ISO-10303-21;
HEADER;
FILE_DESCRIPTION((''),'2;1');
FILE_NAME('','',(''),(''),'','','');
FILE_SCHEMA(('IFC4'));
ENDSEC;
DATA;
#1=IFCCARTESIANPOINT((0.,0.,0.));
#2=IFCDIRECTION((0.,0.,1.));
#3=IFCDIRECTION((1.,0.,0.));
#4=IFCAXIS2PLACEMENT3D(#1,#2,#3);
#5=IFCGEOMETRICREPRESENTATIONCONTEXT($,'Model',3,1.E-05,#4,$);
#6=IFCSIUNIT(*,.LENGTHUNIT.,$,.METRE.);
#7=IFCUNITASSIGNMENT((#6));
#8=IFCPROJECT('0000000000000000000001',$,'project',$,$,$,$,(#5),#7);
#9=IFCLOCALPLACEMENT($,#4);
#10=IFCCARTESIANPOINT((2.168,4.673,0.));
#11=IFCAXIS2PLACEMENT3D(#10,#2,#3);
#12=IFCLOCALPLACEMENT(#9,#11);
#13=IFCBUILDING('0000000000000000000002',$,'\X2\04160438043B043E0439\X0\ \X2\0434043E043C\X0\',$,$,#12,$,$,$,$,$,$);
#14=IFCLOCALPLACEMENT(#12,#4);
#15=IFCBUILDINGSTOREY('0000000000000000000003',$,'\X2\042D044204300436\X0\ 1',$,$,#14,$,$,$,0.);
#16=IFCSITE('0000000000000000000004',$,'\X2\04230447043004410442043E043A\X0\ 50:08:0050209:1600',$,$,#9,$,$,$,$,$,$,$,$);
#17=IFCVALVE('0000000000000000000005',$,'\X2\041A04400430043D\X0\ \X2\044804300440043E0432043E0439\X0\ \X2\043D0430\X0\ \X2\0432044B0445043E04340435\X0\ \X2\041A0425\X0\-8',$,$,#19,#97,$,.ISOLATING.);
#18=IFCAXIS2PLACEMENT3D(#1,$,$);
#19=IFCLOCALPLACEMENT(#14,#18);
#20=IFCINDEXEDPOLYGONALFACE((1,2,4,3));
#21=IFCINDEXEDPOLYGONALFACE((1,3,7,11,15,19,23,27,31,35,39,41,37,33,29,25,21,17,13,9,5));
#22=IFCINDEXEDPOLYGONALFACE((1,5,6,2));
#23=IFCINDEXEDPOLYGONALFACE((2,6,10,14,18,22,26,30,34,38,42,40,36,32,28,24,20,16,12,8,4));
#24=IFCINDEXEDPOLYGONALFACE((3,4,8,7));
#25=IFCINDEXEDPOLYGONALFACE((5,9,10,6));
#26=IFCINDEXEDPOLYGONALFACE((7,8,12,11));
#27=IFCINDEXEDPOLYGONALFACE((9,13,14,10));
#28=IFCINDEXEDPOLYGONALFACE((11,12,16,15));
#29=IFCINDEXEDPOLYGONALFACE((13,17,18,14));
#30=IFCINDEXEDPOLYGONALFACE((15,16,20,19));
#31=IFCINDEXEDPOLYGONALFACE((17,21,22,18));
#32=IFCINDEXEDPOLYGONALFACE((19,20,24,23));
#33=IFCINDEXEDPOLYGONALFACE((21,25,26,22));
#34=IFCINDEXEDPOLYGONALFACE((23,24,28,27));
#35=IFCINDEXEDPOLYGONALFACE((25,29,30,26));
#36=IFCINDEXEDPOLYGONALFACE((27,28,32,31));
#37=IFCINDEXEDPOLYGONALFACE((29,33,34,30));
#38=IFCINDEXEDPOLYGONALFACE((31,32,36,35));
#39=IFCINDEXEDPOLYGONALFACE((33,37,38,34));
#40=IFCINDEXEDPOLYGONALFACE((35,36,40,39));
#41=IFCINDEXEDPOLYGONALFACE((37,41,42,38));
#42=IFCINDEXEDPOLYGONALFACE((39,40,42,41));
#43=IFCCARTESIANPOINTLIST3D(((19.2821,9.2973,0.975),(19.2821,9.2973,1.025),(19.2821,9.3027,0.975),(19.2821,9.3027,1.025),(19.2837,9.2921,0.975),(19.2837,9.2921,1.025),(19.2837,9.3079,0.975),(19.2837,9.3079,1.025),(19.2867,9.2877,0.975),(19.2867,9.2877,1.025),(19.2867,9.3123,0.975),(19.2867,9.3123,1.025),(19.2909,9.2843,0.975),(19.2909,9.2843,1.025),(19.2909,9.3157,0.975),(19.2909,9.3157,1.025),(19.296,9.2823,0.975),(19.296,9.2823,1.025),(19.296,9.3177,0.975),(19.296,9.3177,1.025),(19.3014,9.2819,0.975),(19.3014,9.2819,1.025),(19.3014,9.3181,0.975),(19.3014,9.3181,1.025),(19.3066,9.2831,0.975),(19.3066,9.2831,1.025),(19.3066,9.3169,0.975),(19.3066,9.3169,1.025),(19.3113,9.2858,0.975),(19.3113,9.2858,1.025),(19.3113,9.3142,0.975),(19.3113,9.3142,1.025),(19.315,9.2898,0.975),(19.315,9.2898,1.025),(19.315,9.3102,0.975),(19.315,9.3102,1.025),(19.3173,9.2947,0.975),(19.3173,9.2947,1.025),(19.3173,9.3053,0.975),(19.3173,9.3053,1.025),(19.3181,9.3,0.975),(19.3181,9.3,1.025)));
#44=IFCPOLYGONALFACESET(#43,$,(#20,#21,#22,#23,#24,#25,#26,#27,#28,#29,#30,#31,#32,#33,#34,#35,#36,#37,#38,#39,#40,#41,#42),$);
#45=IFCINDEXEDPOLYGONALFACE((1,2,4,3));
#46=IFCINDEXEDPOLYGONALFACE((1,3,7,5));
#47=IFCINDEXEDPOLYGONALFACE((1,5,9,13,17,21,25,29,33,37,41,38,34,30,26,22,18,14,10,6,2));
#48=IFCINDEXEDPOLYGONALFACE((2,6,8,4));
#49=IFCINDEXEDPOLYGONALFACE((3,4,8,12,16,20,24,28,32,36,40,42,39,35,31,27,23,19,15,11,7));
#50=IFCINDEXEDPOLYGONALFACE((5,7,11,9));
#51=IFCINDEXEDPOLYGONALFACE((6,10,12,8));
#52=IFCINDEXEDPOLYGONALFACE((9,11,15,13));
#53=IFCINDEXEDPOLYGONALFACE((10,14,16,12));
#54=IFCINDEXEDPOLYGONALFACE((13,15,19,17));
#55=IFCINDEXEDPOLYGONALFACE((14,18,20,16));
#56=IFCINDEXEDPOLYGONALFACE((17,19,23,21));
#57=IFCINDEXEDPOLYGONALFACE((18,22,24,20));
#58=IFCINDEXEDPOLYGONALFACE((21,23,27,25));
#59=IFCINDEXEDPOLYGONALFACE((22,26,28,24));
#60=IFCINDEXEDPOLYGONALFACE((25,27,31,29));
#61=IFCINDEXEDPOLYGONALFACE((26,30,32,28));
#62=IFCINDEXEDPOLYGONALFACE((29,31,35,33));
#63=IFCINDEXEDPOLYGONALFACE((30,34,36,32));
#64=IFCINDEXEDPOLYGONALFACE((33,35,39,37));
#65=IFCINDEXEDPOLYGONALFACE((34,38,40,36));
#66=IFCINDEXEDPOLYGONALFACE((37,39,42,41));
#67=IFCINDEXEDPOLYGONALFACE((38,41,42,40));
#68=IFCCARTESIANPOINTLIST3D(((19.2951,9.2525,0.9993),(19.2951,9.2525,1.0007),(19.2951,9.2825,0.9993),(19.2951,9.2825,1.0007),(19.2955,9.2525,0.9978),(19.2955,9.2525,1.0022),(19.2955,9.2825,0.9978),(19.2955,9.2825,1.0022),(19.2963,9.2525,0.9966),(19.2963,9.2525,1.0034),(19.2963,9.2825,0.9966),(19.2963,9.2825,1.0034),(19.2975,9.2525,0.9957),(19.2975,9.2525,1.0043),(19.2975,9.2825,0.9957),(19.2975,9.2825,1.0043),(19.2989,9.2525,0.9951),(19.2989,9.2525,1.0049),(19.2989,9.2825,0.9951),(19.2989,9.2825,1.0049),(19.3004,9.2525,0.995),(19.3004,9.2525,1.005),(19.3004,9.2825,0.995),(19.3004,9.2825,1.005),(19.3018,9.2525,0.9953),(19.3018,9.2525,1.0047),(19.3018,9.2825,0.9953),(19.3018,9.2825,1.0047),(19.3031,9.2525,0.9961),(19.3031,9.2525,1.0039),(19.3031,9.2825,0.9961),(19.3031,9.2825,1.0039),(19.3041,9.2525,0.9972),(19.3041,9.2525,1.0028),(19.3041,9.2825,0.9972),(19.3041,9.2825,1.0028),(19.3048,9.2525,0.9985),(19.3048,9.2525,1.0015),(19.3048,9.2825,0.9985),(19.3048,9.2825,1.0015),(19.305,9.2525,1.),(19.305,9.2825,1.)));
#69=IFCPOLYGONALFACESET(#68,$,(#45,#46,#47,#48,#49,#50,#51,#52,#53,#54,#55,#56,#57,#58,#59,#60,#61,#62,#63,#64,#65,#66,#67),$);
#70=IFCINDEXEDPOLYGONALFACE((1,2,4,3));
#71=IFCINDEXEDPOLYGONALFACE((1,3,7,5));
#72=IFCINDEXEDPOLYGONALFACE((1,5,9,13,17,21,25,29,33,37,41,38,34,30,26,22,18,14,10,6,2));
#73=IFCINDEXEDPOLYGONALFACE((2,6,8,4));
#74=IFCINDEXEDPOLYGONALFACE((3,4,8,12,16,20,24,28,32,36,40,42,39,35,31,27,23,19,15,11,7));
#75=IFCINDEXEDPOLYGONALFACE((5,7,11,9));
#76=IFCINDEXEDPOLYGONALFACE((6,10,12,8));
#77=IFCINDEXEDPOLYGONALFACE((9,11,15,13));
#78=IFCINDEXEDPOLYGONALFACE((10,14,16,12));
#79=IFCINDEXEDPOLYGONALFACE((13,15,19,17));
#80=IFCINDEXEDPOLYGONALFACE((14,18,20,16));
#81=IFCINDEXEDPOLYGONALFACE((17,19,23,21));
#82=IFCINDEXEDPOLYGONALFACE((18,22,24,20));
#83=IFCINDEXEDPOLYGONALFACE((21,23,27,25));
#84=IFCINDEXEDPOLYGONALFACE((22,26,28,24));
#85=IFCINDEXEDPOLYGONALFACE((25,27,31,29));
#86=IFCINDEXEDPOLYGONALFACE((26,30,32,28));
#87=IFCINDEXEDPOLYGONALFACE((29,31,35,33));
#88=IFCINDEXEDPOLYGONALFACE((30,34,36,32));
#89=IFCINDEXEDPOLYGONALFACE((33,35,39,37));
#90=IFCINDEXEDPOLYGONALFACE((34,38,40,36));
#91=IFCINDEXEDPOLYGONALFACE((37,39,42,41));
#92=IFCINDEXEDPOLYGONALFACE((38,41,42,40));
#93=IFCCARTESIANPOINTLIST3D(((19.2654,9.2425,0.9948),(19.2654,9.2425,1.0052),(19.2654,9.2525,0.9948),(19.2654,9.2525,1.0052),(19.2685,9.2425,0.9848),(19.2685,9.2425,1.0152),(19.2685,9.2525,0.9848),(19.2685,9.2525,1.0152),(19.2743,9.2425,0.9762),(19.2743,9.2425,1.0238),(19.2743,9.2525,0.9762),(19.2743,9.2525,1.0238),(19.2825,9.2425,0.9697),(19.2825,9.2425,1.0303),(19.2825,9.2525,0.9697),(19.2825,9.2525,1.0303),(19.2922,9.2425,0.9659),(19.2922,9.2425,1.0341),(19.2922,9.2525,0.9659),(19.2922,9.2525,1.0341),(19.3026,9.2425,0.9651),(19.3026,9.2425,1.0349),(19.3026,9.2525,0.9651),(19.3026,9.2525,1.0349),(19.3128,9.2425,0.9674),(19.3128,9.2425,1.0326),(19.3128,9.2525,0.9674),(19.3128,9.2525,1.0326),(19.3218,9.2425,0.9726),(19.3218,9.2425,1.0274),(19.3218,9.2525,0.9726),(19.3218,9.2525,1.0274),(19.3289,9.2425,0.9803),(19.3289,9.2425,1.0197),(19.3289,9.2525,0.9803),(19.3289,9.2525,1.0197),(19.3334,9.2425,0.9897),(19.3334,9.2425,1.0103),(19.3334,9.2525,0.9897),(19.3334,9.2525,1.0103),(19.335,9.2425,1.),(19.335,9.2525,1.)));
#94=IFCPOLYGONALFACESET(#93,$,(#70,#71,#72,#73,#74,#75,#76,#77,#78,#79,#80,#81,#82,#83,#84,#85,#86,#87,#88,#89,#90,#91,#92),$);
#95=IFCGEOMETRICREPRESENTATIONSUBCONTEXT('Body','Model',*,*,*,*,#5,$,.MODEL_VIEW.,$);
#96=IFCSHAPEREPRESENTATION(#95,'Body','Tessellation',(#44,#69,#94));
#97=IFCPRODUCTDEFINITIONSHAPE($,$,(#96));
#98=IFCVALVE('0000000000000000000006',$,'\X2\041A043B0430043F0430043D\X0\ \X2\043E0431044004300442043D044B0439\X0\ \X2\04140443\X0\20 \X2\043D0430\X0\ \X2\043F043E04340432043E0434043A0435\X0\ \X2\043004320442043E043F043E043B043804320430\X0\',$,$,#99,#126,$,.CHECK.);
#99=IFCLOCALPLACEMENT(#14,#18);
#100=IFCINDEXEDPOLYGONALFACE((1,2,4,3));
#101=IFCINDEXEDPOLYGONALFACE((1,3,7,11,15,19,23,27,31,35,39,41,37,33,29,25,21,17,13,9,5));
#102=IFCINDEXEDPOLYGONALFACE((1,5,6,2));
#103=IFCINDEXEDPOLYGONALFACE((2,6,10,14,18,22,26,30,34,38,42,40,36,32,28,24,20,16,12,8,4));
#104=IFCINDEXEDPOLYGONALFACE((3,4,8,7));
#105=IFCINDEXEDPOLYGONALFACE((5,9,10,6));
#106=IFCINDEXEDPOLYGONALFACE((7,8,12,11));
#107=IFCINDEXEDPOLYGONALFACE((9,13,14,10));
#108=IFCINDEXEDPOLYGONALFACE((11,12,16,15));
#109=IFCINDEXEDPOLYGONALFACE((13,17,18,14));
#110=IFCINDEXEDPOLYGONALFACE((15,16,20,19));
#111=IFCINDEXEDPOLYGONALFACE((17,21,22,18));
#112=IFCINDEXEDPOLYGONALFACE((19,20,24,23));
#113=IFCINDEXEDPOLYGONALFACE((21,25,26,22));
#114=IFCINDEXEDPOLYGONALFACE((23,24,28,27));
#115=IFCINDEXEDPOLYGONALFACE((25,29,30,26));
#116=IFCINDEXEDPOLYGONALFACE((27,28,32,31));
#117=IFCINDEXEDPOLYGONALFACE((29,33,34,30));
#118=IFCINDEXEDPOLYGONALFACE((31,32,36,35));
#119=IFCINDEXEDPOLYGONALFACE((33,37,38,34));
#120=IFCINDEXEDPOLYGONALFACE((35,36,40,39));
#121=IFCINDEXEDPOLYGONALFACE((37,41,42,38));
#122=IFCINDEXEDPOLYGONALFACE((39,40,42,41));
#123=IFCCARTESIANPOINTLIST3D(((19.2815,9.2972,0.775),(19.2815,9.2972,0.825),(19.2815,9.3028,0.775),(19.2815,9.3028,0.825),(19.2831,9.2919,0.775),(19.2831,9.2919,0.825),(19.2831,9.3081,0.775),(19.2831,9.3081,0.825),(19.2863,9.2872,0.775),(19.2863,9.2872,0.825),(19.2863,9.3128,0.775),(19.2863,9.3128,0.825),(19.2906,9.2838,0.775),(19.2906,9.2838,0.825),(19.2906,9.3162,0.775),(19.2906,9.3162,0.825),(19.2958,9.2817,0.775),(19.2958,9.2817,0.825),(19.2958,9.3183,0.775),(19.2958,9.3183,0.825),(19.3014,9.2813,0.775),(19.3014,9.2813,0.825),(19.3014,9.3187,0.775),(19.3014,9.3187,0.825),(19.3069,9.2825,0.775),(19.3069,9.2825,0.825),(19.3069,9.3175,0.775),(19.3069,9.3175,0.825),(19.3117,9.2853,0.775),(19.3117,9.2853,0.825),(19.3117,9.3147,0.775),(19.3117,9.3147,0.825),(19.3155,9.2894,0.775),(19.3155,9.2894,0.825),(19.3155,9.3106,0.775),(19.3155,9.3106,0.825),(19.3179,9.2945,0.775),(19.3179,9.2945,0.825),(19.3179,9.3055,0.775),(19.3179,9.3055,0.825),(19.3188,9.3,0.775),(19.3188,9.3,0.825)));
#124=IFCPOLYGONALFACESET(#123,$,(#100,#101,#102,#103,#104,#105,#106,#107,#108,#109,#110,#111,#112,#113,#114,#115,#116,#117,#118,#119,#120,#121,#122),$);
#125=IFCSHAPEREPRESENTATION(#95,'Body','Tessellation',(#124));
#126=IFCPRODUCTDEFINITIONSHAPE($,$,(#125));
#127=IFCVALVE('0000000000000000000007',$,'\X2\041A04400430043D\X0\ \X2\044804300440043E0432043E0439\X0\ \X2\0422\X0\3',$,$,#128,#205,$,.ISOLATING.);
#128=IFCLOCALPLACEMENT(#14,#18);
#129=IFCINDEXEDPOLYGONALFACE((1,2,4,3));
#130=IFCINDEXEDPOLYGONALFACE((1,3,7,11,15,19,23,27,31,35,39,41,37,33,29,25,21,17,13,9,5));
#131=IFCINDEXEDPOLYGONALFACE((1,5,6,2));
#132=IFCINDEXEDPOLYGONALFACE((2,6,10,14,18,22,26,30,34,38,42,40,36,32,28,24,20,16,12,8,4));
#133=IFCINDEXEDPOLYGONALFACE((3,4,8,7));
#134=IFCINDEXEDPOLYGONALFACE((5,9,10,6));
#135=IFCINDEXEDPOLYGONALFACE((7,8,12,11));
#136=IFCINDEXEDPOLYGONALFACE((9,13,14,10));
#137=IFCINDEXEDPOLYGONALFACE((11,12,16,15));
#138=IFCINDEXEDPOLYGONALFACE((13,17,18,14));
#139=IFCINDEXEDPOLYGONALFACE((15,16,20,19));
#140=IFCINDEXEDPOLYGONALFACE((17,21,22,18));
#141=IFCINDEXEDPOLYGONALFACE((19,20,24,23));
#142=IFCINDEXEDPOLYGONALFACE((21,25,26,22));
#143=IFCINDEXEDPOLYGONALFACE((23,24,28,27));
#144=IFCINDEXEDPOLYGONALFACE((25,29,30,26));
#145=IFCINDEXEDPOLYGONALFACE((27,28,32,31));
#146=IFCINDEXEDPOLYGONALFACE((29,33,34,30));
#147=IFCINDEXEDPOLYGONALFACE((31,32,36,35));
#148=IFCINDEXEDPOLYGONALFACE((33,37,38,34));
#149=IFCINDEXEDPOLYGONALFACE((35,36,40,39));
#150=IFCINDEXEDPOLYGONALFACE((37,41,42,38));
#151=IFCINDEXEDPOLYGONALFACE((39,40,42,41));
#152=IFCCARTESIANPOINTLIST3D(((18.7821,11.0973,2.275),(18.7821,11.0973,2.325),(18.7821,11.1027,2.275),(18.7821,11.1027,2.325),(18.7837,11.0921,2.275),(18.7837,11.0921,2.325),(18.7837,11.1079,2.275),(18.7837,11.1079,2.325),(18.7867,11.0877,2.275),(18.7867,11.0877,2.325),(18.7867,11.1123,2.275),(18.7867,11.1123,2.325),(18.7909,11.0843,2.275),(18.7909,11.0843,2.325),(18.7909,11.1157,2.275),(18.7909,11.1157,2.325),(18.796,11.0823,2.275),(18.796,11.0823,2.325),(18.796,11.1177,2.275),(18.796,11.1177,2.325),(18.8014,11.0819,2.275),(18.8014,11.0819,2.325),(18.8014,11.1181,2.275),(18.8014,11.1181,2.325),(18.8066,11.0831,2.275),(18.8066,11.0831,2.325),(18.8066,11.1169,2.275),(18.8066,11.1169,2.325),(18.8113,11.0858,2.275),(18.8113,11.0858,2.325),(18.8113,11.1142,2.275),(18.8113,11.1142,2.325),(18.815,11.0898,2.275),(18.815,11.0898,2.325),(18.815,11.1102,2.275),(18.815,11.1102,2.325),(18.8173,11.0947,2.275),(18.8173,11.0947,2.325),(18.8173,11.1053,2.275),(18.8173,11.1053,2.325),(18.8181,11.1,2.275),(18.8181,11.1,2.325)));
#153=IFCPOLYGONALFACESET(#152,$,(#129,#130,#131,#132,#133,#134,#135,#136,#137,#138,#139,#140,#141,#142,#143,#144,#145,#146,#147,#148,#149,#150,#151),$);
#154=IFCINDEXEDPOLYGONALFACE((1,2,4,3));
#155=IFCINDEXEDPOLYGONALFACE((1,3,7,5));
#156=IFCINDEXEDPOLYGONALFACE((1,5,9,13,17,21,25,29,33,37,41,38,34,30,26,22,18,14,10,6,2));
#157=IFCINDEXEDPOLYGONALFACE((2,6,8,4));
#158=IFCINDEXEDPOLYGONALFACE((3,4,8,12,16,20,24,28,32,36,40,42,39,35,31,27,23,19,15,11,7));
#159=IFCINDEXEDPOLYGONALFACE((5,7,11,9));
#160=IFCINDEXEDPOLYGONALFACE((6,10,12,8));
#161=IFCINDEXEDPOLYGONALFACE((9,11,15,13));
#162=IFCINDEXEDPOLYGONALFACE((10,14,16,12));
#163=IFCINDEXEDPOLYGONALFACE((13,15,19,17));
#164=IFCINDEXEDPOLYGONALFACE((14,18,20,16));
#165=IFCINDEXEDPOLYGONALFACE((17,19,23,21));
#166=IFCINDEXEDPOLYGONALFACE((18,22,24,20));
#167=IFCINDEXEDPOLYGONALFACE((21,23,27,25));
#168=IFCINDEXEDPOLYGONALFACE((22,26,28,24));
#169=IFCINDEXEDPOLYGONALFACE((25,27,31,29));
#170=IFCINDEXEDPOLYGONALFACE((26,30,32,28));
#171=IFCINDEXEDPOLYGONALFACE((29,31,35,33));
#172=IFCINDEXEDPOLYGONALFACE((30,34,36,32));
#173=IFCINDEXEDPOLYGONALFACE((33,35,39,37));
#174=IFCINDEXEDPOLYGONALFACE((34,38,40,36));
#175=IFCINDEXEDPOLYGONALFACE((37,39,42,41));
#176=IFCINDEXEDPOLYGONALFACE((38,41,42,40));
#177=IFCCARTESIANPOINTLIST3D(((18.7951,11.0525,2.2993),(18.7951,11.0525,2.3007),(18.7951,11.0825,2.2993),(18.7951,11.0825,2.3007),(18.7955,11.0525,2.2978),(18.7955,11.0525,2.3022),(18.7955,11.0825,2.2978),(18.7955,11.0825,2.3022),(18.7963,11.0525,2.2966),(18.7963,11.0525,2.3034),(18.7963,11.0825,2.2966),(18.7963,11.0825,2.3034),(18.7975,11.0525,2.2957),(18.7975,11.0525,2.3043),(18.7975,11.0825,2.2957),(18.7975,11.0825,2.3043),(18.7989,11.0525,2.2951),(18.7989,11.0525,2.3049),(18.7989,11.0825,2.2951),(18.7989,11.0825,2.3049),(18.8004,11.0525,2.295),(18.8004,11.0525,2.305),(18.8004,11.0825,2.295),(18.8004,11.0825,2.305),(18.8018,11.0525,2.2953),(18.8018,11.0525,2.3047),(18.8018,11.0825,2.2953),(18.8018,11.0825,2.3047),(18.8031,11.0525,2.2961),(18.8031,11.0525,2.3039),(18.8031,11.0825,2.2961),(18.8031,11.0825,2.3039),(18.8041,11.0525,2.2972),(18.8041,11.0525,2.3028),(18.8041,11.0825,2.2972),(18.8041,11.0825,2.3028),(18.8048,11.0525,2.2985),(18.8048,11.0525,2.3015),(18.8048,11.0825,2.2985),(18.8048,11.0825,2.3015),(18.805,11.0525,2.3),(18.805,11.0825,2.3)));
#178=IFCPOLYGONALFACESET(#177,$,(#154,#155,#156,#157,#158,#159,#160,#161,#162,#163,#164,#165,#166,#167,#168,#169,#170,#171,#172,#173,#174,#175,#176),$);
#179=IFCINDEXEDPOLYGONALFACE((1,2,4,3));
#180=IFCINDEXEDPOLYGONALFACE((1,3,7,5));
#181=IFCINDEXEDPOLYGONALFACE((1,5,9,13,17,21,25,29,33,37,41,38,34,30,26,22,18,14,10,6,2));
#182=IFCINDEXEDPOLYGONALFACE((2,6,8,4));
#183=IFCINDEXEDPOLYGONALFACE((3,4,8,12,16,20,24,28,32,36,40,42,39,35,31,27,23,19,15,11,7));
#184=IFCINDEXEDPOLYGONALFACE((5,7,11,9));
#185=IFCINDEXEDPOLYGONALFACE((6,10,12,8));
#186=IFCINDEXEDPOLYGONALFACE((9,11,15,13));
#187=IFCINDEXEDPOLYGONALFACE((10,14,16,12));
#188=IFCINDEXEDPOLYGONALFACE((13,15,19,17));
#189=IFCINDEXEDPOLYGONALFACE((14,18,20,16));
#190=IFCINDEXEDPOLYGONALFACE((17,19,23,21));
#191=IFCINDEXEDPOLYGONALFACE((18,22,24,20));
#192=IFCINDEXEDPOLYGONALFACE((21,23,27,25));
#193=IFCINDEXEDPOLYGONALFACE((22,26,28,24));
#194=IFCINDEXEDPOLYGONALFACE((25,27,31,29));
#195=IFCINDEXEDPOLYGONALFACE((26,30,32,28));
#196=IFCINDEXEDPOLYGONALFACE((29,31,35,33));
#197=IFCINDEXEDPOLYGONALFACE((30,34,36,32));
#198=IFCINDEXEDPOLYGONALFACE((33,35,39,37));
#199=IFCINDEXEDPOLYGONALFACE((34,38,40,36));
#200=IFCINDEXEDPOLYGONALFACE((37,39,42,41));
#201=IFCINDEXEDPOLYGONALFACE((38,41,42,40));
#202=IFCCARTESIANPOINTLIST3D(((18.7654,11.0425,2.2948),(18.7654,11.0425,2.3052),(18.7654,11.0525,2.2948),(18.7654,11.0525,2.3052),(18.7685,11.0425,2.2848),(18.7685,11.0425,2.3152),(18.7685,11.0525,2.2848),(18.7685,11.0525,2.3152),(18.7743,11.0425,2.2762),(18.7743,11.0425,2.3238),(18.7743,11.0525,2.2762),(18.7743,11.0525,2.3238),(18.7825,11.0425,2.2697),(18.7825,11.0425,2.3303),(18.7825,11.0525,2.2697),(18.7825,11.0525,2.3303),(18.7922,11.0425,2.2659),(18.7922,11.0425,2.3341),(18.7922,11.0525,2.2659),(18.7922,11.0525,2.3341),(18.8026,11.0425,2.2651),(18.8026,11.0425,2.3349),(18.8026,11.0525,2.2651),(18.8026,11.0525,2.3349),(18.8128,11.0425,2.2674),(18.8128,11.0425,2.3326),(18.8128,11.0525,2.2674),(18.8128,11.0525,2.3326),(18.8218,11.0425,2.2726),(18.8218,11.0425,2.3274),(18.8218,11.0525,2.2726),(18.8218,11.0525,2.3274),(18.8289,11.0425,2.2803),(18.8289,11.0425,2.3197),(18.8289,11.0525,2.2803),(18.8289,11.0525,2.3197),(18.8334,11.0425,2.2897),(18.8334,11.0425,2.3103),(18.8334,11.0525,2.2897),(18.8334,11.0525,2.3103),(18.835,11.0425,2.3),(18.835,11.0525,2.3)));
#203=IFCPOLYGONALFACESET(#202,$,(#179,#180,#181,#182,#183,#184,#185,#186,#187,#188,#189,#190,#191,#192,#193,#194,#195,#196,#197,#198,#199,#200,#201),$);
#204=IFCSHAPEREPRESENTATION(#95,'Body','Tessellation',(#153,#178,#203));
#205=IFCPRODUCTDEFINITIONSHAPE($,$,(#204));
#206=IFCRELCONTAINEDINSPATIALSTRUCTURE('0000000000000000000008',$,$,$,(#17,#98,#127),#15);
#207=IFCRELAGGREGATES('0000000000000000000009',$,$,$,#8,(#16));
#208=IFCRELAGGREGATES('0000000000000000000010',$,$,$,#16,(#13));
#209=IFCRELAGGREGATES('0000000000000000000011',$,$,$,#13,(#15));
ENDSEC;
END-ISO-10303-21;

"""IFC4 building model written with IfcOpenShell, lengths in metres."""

from ifc_helpers import new_model, si_unit, frame, origin_with_axes, origin_2d, place, context, subcontext, project, spatial, circle, extrude, element, save


model = new_model("IFC4")

# Units and contexts
model_context = context("Model", 3, precision=1e-05, world=origin_with_axes())
body_context = subcontext(model_context, "Body", "Model", "MODEL_VIEW")
ifc_project = project(units=[si_unit("LENGTHUNIT", "METRE")], contexts=[model_context])

# Site, building, storey
site_placement = place(None, origin_with_axes())
site = spatial("IfcSite", under=ifc_project, at=site_placement, Name="Участок 50:08:0050209:1600")
building_placement = place(site_placement, frame((2.168, 4.673, 0.0), z_axis=(0.0, 0.0, 1.0), x_axis=(1.0, 0.0, 0.0)))
building = spatial("IfcBuilding", under=site, at=building_placement, Name="Жилой дом")
storey_placement = place(building_placement, origin_with_axes())
storey = spatial("IfcBuildingStorey", under=building, at=storey_placement, Name="Этаж 1", Elevation=0.0)

# Valves
valve_1_placement = place(storey_placement, origin_with_axes())
element("IfcValve", 1, at=valve_1_placement, inside=storey, Name="Кран шаровой на выходе КХ-8", PredefinedType="ISOLATING", context=body_context, shape_type="SweptSolid", body=[
    extrude(circle(Radius=0.0181, at=origin_2d()), frame((19.3, 9.3, 0.975), z_axis=(0.0, 0.0, 1.0), x_axis=(1.0, 0.0, 0.0)), (0.0, 0.0, 1.0), 0.05),
    extrude(circle(Radius=0.005, at=origin_2d()), frame((19.3, 9.2825, 1.0), z_axis=(0.0, -1.0, 0.0), x_axis=(1.0, 0.0, 0.0)), (0.0, 0.0, 1.0), 0.03),
    extrude(circle(Radius=0.035, at=origin_2d()), frame((19.3, 9.2525, 1.0), z_axis=(0.0, -1.0, 0.0), x_axis=(1.0, 0.0, 0.0)), (0.0, 0.0, 1.0), 0.01),
])
valve_2_placement = place(storey_placement, origin_with_axes())
element("IfcValve", 2, at=valve_2_placement, inside=storey, Name="Клапан обратный Ду20 на подводке автополива", PredefinedType="CHECK", context=body_context, shape_type="SweptSolid", body=[
    extrude(circle(Radius=0.0188, at=origin_2d()), frame((19.3, 9.3, 0.775), z_axis=(0.0, 0.0, 1.0), x_axis=(1.0, 0.0, 0.0)), (0.0, 0.0, 1.0), 0.05),
])
valve_3_placement = place(storey_placement, origin_with_axes())
element("IfcValve", 3, at=valve_3_placement, inside=storey, Name="Кран шаровой Т3", PredefinedType="ISOLATING", context=body_context, shape_type="SweptSolid", body=[
    extrude(circle(Radius=0.0181, at=origin_2d()), frame((18.8, 11.1, 2.275), z_axis=(0.0, 0.0, 1.0), x_axis=(1.0, 0.0, 0.0)), (0.0, 0.0, 1.0), 0.05),
    extrude(circle(Radius=0.005, at=origin_2d()), frame((18.8, 11.0825, 2.3), z_axis=(0.0, -1.0, 0.0), x_axis=(1.0, 0.0, 0.0)), (0.0, 0.0, 1.0), 0.03),
    extrude(circle(Radius=0.035, at=origin_2d()), frame((18.8, 11.0525, 2.3), z_axis=(0.0, -1.0, 0.0), x_axis=(1.0, 0.0, 0.0)), (0.0, 0.0, 1.0), 0.01),
])

save(model, "model.ifc")
